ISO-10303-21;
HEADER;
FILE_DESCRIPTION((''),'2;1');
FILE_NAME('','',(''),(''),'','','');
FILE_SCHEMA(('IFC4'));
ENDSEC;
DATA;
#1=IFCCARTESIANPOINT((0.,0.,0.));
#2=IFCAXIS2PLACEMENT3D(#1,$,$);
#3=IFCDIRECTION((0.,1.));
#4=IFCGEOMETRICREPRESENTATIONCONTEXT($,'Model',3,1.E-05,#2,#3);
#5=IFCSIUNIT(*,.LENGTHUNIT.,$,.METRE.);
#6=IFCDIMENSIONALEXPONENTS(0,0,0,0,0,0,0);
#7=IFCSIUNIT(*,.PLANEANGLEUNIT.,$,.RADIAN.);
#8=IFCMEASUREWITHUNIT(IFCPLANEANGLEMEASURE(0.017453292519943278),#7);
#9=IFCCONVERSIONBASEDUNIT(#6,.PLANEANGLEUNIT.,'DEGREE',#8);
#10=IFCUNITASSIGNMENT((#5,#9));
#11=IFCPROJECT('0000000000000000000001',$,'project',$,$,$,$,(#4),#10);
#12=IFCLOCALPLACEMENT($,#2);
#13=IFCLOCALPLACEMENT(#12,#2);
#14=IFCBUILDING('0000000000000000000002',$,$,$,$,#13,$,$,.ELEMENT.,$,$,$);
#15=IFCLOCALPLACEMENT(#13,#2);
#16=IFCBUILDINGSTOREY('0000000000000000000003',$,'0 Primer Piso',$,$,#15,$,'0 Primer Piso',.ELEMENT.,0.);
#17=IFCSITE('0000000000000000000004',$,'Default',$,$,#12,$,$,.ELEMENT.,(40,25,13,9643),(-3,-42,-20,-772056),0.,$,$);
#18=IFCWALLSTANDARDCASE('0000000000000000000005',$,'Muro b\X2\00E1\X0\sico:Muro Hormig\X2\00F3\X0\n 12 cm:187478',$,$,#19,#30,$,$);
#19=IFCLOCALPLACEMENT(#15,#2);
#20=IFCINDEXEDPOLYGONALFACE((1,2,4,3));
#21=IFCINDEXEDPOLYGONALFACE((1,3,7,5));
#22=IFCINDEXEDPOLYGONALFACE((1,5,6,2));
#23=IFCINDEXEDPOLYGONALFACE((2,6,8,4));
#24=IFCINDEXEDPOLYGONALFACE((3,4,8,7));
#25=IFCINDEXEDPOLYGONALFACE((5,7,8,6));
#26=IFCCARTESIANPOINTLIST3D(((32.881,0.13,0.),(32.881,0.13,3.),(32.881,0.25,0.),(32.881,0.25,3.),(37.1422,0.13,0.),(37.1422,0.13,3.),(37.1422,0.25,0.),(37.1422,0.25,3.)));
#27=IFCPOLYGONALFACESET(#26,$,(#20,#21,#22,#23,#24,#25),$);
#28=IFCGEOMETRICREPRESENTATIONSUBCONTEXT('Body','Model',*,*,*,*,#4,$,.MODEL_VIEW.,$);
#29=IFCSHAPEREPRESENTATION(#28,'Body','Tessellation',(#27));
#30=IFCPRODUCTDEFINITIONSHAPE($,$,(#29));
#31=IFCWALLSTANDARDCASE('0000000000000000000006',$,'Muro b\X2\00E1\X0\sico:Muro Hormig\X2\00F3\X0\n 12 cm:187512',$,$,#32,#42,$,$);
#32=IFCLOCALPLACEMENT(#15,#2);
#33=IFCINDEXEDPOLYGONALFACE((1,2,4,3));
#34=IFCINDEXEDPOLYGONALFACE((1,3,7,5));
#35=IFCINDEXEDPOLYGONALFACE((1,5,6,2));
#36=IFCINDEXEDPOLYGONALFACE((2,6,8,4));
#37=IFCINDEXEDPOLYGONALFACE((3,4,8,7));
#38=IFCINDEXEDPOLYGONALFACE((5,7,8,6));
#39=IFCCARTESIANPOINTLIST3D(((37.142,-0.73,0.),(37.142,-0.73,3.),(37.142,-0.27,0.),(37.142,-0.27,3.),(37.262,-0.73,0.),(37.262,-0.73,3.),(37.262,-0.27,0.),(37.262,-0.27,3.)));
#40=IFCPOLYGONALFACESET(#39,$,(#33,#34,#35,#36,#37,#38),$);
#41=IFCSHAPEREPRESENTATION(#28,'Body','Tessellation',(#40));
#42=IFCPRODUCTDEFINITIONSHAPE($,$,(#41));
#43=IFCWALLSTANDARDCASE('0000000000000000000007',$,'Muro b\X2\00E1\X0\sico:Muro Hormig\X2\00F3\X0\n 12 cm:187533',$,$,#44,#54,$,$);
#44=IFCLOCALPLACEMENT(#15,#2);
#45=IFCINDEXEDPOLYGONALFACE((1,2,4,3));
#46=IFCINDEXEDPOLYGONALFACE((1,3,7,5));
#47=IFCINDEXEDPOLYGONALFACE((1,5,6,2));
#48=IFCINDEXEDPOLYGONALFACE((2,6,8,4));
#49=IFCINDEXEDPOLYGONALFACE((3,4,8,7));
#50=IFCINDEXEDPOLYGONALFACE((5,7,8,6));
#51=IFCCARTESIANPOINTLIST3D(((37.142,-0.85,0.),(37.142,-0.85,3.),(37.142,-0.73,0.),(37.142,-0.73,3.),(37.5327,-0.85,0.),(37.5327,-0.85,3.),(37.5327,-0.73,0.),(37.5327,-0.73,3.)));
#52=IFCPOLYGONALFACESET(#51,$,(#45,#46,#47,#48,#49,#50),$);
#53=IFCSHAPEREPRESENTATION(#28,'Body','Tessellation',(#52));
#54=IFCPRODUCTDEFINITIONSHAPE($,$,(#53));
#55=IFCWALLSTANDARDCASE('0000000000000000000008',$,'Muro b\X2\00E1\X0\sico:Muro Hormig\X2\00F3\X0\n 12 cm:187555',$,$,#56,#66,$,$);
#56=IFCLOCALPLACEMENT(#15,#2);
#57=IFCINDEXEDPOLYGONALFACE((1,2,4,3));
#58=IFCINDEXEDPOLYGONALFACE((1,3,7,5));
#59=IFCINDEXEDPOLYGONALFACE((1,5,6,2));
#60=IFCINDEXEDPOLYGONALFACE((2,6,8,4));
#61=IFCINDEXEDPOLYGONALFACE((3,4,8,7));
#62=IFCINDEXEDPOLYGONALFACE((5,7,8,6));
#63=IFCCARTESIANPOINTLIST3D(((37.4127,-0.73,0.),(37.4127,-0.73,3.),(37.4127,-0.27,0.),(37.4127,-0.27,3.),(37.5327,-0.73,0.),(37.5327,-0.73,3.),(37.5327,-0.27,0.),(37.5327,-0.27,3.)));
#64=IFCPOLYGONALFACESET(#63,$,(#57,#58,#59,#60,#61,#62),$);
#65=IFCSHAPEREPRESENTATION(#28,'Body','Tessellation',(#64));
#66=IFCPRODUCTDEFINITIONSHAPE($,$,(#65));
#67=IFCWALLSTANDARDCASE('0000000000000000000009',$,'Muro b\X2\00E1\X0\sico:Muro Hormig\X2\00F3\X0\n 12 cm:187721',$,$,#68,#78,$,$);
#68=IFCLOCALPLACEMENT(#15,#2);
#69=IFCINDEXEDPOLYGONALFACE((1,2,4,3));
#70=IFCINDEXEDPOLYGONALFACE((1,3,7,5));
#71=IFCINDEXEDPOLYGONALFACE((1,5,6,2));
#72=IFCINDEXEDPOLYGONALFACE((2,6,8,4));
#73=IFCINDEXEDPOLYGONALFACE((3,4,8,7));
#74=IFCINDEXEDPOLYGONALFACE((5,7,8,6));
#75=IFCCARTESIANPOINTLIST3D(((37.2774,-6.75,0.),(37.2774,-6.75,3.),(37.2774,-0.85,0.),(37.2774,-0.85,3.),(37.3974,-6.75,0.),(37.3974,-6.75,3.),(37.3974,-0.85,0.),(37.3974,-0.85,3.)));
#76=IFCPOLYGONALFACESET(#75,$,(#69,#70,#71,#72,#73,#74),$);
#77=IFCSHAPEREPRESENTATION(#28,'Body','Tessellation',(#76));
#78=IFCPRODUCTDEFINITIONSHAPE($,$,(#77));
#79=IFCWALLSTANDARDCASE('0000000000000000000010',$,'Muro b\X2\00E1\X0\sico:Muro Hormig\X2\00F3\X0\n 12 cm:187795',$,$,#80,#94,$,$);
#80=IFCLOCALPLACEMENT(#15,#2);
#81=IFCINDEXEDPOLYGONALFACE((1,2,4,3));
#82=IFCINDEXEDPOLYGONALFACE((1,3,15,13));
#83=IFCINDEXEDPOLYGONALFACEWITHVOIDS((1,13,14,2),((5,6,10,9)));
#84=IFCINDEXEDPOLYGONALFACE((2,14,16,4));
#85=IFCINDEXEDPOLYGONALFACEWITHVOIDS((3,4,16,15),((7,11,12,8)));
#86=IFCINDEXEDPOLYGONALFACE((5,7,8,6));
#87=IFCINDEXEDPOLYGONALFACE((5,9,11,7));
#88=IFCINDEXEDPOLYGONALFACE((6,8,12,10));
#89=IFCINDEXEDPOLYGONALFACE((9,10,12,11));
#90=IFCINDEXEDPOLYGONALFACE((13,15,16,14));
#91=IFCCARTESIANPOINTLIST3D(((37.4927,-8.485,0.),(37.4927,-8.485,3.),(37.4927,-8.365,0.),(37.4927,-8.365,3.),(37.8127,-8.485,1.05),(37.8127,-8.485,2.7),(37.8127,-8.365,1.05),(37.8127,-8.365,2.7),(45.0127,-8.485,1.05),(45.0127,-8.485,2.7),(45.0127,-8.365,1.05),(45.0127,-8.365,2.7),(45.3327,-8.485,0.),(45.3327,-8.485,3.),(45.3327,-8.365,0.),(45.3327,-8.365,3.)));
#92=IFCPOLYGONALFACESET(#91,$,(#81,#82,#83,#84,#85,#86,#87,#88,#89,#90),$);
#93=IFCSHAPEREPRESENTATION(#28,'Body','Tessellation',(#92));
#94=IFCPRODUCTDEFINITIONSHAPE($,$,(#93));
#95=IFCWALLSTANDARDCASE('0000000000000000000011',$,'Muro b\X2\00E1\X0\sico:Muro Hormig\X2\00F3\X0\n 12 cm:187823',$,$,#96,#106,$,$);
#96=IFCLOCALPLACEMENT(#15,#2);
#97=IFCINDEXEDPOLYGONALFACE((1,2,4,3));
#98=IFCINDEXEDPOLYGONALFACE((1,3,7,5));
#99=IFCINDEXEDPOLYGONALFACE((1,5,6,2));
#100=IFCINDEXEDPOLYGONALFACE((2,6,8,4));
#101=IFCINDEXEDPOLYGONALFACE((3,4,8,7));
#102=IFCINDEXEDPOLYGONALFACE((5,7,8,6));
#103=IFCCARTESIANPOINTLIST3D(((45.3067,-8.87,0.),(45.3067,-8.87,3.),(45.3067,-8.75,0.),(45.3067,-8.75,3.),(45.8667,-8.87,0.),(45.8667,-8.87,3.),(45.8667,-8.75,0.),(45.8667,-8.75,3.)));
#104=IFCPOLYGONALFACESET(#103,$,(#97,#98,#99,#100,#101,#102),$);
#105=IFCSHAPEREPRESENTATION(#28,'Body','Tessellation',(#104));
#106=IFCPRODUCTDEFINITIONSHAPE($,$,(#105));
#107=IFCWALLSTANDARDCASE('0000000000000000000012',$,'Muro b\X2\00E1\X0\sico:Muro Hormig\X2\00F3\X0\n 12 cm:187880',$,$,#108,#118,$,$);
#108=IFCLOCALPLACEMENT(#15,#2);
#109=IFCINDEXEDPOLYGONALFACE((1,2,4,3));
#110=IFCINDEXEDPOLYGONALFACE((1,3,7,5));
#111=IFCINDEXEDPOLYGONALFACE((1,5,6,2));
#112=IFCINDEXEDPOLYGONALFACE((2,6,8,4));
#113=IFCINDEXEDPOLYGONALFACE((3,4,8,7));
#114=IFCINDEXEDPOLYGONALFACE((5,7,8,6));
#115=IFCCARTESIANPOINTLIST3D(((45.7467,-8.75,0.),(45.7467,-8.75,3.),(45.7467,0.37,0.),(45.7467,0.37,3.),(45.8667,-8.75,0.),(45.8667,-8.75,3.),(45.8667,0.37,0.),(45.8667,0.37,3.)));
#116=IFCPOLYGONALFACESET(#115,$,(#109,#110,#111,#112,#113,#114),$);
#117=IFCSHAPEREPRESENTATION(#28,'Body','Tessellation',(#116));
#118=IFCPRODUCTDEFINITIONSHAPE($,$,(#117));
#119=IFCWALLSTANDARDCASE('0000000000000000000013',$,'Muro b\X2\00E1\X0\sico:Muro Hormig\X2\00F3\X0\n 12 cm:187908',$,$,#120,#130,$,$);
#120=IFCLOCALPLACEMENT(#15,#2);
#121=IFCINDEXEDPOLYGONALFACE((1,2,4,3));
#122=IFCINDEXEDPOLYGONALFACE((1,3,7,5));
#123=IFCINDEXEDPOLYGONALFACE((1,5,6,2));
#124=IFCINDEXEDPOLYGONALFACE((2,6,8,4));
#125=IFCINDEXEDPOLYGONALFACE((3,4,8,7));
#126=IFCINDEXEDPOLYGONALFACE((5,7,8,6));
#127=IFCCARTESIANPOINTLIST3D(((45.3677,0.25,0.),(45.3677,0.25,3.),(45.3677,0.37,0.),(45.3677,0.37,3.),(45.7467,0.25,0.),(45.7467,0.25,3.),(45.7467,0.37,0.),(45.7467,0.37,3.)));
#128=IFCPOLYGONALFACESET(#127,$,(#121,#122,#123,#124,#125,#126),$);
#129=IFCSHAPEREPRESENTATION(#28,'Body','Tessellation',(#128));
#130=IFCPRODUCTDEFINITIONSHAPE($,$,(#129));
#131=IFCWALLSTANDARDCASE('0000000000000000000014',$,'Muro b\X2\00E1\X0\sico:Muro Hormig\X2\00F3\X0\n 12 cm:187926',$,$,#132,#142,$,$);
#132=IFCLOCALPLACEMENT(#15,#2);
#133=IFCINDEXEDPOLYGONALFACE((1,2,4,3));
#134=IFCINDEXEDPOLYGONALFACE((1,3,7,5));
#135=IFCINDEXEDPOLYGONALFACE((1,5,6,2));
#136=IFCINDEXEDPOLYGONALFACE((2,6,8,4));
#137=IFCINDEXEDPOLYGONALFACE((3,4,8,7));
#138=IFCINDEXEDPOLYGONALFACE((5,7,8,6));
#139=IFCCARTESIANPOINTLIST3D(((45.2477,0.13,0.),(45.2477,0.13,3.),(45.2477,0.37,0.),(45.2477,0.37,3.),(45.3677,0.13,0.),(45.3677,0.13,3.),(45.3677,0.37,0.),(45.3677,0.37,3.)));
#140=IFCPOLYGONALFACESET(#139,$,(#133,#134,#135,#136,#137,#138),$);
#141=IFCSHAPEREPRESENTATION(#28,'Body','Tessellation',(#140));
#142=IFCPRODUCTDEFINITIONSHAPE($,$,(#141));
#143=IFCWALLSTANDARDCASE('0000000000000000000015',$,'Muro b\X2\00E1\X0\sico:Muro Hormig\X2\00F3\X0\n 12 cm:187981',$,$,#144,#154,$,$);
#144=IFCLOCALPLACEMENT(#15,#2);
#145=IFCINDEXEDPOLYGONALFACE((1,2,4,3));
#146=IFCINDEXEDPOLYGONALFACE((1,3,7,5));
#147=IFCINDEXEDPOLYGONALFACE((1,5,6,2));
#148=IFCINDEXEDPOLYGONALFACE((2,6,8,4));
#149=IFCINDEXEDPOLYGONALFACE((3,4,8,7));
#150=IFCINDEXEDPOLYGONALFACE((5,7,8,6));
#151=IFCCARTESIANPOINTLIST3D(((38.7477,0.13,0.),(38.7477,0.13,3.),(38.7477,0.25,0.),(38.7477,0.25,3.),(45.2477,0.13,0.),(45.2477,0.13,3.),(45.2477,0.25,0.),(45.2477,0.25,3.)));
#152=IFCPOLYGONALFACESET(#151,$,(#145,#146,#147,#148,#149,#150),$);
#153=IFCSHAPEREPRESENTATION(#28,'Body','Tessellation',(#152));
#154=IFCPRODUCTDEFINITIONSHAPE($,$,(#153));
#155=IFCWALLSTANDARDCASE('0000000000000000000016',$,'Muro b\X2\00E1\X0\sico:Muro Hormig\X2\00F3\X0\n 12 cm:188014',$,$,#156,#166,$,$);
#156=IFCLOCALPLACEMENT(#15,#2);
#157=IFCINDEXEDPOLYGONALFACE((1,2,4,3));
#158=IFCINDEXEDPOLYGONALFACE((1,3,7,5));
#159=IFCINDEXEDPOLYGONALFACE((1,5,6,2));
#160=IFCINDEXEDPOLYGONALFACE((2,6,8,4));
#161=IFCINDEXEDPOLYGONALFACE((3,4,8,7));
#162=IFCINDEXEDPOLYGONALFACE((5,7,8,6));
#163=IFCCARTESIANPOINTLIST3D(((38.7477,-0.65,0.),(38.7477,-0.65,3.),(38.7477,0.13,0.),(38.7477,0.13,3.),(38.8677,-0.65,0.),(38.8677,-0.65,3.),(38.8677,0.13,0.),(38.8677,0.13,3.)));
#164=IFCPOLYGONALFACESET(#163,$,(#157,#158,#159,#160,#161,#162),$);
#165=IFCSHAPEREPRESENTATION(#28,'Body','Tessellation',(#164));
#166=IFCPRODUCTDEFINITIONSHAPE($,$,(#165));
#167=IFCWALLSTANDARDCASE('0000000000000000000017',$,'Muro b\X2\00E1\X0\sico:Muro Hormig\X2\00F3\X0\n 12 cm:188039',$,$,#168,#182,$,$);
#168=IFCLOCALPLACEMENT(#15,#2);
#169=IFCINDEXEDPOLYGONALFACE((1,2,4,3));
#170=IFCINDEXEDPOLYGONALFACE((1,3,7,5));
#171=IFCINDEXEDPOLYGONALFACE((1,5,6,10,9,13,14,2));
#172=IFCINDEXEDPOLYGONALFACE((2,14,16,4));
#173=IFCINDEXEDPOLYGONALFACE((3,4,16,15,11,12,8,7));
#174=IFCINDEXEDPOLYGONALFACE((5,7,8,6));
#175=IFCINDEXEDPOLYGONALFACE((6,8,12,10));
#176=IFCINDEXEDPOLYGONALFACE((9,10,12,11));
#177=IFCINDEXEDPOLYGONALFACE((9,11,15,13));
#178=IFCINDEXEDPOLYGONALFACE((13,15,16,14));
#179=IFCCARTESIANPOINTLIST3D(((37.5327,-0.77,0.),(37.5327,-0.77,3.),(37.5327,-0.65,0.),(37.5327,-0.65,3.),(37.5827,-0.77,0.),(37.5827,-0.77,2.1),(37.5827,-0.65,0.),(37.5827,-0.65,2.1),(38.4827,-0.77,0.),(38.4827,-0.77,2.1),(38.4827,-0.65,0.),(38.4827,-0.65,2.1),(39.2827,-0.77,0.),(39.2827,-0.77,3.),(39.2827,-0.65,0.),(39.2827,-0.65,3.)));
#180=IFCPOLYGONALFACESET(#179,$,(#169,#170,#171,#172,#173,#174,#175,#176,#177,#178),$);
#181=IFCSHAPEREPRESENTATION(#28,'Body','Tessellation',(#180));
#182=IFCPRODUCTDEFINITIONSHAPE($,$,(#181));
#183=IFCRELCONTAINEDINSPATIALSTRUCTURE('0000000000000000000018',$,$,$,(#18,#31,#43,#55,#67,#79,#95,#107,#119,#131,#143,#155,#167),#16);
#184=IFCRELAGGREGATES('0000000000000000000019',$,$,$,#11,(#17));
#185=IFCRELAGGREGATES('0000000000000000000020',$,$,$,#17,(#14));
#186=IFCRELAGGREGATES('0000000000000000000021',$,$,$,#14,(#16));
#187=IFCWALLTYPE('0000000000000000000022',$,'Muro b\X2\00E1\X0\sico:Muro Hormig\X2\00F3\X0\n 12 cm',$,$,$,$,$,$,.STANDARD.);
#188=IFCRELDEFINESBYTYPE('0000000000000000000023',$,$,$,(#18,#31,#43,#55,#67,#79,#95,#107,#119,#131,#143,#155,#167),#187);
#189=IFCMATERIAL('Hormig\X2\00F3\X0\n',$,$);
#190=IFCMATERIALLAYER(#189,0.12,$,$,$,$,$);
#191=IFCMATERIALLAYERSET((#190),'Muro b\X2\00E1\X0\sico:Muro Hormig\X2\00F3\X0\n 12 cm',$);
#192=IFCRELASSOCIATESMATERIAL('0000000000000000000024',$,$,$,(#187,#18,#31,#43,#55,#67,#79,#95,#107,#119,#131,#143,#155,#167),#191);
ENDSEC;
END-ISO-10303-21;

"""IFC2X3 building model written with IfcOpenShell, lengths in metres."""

from ifc_helpers import new_model, entity, si_unit, converted_unit, direction, frame, frame_2d, origin, place, context, subcontext, project, spatial, rectangle, extrude, material, layer, layer_set, layer_usage, type_object, element, save


model = new_model("IFC2X3")

# Units and contexts
model_context = context("Model", 3, precision=1e-05, world=origin(), true_north=direction((0.0, 1.0)))
body_context = subcontext(model_context, "Body", "Model", "MODEL_VIEW")
ifc_project = project(units=[si_unit("LENGTHUNIT", "METRE"), converted_unit("PLANEANGLEUNIT", "DEGREE", entity("IfcPlaneAngleMeasure", 0.017453292519943278), si_unit("PLANEANGLEUNIT", "RADIAN"), dimensions=[0, 0, 0, 0, 0, 0, 0])], contexts=[model_context])

# Site, building, storey
site_placement = place(None, origin())
site = spatial("IfcSite", under=ifc_project, at=site_placement, Name="Default", CompositionType="ELEMENT", RefLatitude=(40, 25, 13, 9643), RefLongitude=(-3, -42, -20, -772056), RefElevation=0.0)
building_placement = place(site_placement, origin())
building = spatial("IfcBuilding", under=site, at=building_placement, CompositionType="ELEMENT")
storey_placement = place(building_placement, origin())
storey = spatial("IfcBuildingStorey", under=building, at=storey_placement, Name="0 Primer Piso", LongName="0 Primer Piso", CompositionType="ELEMENT", Elevation=0.0)

# Shared definitions
ifc_material = material(Name="Hormigón")
ifc_layer = layer(ifc_material, 0.12)
ifc_layer_set = layer_set([ifc_layer], Name="Muro básico:Muro Hormigón 12 cm")
wall_type = type_object("IfcWallType", Name="Muro básico:Muro Hormigón 12 cm", PredefinedType="STANDARD", material=ifc_layer_set)

# Walls
ifc_layer_usage_1 = layer_usage(ifc_layer_set, "AXIS2", "NEGATIVE", 0.06)
wall_1_placement = place(storey_placement, frame((32.881, 0.19, 0.0)))
element("IfcWallStandardCase", 1, at=wall_1_placement, inside=storey, type_object=wall_type, material=ifc_layer_usage_1, Name="Muro básico:Muro Hormigón 12 cm:187478", context=body_context, shape_type="SweptSolid", body=[
    extrude(rectangle(XDim=4.2611, YDim=0.12, at=frame_2d((2.1306, 0.0), x_axis=(-1.0, 0.0))), origin(), (0.0, 0.0, 1.0), 3.0),
])
ifc_layer_usage_2 = layer_usage(ifc_layer_set, "AXIS2", "NEGATIVE", 0.06)
wall_2_placement = place(storey_placement, frame((37.202, -0.27, 0.0), z_axis=(0.0, 0.0, 1.0), x_axis=(0.0, -1.0, 0.0)))
element("IfcWallStandardCase", 2, at=wall_2_placement, inside=storey, type_object=wall_type, material=ifc_layer_usage_2, Name="Muro básico:Muro Hormigón 12 cm:187512", context=body_context, shape_type="SweptSolid", body=[
    extrude(rectangle(XDim=0.46, YDim=0.12, at=frame_2d((0.23, 0.0), x_axis=(-1.0, 0.0))), origin(), (0.0, 0.0, 1.0), 3.0),
])
ifc_layer_usage_3 = layer_usage(ifc_layer_set, "AXIS2", "NEGATIVE", 0.06)
wall_3_placement = place(storey_placement, frame((37.142, -0.79, 0.0)))
element("IfcWallStandardCase", 3, at=wall_3_placement, inside=storey, type_object=wall_type, material=ifc_layer_usage_3, Name="Muro básico:Muro Hormigón 12 cm:187533", context=body_context, shape_type="SweptSolid", body=[
    extrude(rectangle(XDim=0.3907, YDim=0.12, at=frame_2d((0.1953, 0.0), x_axis=(-1.0, 0.0))), origin(), (0.0, 0.0, 1.0), 3.0),
])
ifc_layer_usage_4 = layer_usage(ifc_layer_set, "AXIS2", "NEGATIVE", 0.06)
wall_4_placement = place(storey_placement, frame((37.4727, -0.73, 0.0), z_axis=(0.0, 0.0, 1.0), x_axis=(0.0, 1.0, 0.0)))
element("IfcWallStandardCase", 4, at=wall_4_placement, inside=storey, type_object=wall_type, material=ifc_layer_usage_4, Name="Muro básico:Muro Hormigón 12 cm:187555", context=body_context, shape_type="SweptSolid", body=[
    extrude(rectangle(XDim=0.46, YDim=0.12, at=frame_2d((0.23, 0.0), x_axis=(-1.0, 0.0))), origin(), (0.0, 0.0, 1.0), 3.0),
])
ifc_layer_usage_5 = layer_usage(ifc_layer_set, "AXIS2", "NEGATIVE", 0.06)
wall_5_placement = place(storey_placement, frame((37.3374, -0.85, 0.0), z_axis=(0.0, 0.0, 1.0), x_axis=(0.0, -1.0, 0.0)))
element("IfcWallStandardCase", 5, at=wall_5_placement, inside=storey, type_object=wall_type, material=ifc_layer_usage_5, Name="Muro básico:Muro Hormigón 12 cm:187721", context=body_context, shape_type="SweptSolid", body=[
    extrude(rectangle(XDim=5.9, YDim=0.12, at=frame_2d((2.95, 0.0), x_axis=(-1.0, 0.0))), origin(), (0.0, 0.0, 1.0), 3.0),
])

# Wall, opening
ifc_layer_usage_6 = layer_usage(ifc_layer_set, "AXIS2", "NEGATIVE", 0.06)
wall_6_placement = place(storey_placement, frame((37.4927, -8.425, 0.0)))
wall_6 = element("IfcWallStandardCase", 6, at=wall_6_placement, inside=storey, type_object=wall_type, material=ifc_layer_usage_6, Name="Muro básico:Muro Hormigón 12 cm:187795", context=body_context, shape_type="SweptSolid", body=[
    extrude(rectangle(XDim=7.84, YDim=0.12, at=frame_2d((3.92, 0.0), x_axis=(-1.0, 0.0))), origin(), (0.0, 0.0, 1.0), 3.0),
])
opening_1_placement = place(wall_6_placement, frame((0.32, -0.06, 1.05)))
element("IfcOpeningElement", 7, at=opening_1_placement, cuts=wall_6, ObjectType="Opening", context=body_context, shape_type="SweptSolid", body=[
    extrude(rectangle(XDim=1.65, YDim=7.2, at=frame_2d((0.825, 3.6), x_axis=(1.0, 0.0))), frame((0.0, 0.0, 0.0), z_axis=(0.0, 1.0, 0.0), x_axis=(0.0, 0.0, 1.0)), (0.0, 0.0, 1.0), 0.12),
])

# Walls
ifc_layer_usage_7 = layer_usage(ifc_layer_set, "AXIS2", "NEGATIVE", 0.06)
wall_7_placement = place(storey_placement, frame((45.3067, -8.81, 0.0)))
element("IfcWallStandardCase", 8, at=wall_7_placement, inside=storey, type_object=wall_type, material=ifc_layer_usage_7, Name="Muro básico:Muro Hormigón 12 cm:187823", context=body_context, shape_type="SweptSolid", body=[
    extrude(rectangle(XDim=0.56, YDim=0.12, at=frame_2d((0.28, 0.0), x_axis=(-1.0, 0.0))), origin(), (0.0, 0.0, 1.0), 3.0),
])
ifc_layer_usage_8 = layer_usage(ifc_layer_set, "AXIS2", "NEGATIVE", 0.06)
wall_8_placement = place(storey_placement, frame((45.8067, -8.75, 0.0), z_axis=(0.0, 0.0, 1.0), x_axis=(0.0, 1.0, 0.0)))
element("IfcWallStandardCase", 9, at=wall_8_placement, inside=storey, type_object=wall_type, material=ifc_layer_usage_8, Name="Muro básico:Muro Hormigón 12 cm:187880", context=body_context, shape_type="SweptSolid", body=[
    extrude(rectangle(XDim=9.12, YDim=0.12, at=frame_2d((4.56, 0.0), x_axis=(-1.0, 0.0))), origin(), (0.0, 0.0, 1.0), 3.0),
])
ifc_layer_usage_9 = layer_usage(ifc_layer_set, "AXIS2", "NEGATIVE", 0.06)
wall_9_placement = place(storey_placement, frame((45.7467, 0.31, 0.0), z_axis=(0.0, 0.0, 1.0), x_axis=(-1.0, 0.0, 0.0)))
element("IfcWallStandardCase", 10, at=wall_9_placement, inside=storey, type_object=wall_type, material=ifc_layer_usage_9, Name="Muro básico:Muro Hormigón 12 cm:187908", context=body_context, shape_type="SweptSolid", body=[
    extrude(rectangle(XDim=0.379, YDim=0.12, at=frame_2d((0.1895, 0.0), x_axis=(-1.0, 0.0))), origin(), (0.0, 0.0, 1.0), 3.0),
])
ifc_layer_usage_10 = layer_usage(ifc_layer_set, "AXIS2", "NEGATIVE", 0.06)
wall_10_placement = place(storey_placement, frame((45.3077, 0.37, 0.0), z_axis=(0.0, 0.0, 1.0), x_axis=(0.0, -1.0, 0.0)))
element("IfcWallStandardCase", 11, at=wall_10_placement, inside=storey, type_object=wall_type, material=ifc_layer_usage_10, Name="Muro básico:Muro Hormigón 12 cm:187926", context=body_context, shape_type="SweptSolid", body=[
    extrude(rectangle(XDim=0.24, YDim=0.12, at=frame_2d((0.12, 0.0), x_axis=(-1.0, 0.0))), origin(), (0.0, 0.0, 1.0), 3.0),
])
ifc_layer_usage_11 = layer_usage(ifc_layer_set, "AXIS2", "NEGATIVE", 0.06)
wall_11_placement = place(storey_placement, frame((45.2477, 0.19, 0.0), z_axis=(0.0, 0.0, 1.0), x_axis=(-1.0, 0.0, 0.0)))
element("IfcWallStandardCase", 12, at=wall_11_placement, inside=storey, type_object=wall_type, material=ifc_layer_usage_11, Name="Muro básico:Muro Hormigón 12 cm:187981", context=body_context, shape_type="SweptSolid", body=[
    extrude(rectangle(XDim=6.5, YDim=0.12, at=frame_2d((3.25, 0.0), x_axis=(-1.0, 0.0))), origin(), (0.0, 0.0, 1.0), 3.0),
])
ifc_layer_usage_12 = layer_usage(ifc_layer_set, "AXIS2", "NEGATIVE", 0.06)
wall_12_placement = place(storey_placement, frame((38.8077, 0.13, 0.0), z_axis=(0.0, 0.0, 1.0), x_axis=(0.0, -1.0, 0.0)))
element("IfcWallStandardCase", 13, at=wall_12_placement, inside=storey, type_object=wall_type, material=ifc_layer_usage_12, Name="Muro básico:Muro Hormigón 12 cm:188014", context=body_context, shape_type="SweptSolid", body=[
    extrude(rectangle(XDim=0.78, YDim=0.12, at=frame_2d((0.39, 0.0), x_axis=(-1.0, 0.0))), origin(), (0.0, 0.0, 1.0), 3.0),
])

# Wall, opening
ifc_layer_usage_13 = layer_usage(ifc_layer_set, "AXIS2", "NEGATIVE", 0.06)
wall_13_placement = place(storey_placement, frame((37.5327, -0.71, 0.0)))
wall_13 = element("IfcWallStandardCase", 14, at=wall_13_placement, inside=storey, type_object=wall_type, material=ifc_layer_usage_13, Name="Muro básico:Muro Hormigón 12 cm:188039", context=body_context, shape_type="SweptSolid", body=[
    extrude(rectangle(XDim=1.75, YDim=0.12, at=frame_2d((0.875, 0.0), x_axis=(-1.0, 0.0))), origin(), (0.0, 0.0, 1.0), 3.0),
])
opening_2_placement = place(wall_13_placement, frame((0.05, -0.06, 0.0)))
element("IfcOpeningElement", 15, at=opening_2_placement, cuts=wall_13, ObjectType="Opening", context=body_context, shape_type="SweptSolid", body=[
    extrude(rectangle(XDim=2.1, YDim=0.9, at=frame_2d((1.05, 0.45), x_axis=(1.0, 0.0))), frame((0.0, 0.0, 0.0), z_axis=(0.0, 1.0, 0.0), x_axis=(0.0, 0.0, 1.0)), (0.0, 0.0, 1.0), 0.12),
])

save(model, "model.ifc")
